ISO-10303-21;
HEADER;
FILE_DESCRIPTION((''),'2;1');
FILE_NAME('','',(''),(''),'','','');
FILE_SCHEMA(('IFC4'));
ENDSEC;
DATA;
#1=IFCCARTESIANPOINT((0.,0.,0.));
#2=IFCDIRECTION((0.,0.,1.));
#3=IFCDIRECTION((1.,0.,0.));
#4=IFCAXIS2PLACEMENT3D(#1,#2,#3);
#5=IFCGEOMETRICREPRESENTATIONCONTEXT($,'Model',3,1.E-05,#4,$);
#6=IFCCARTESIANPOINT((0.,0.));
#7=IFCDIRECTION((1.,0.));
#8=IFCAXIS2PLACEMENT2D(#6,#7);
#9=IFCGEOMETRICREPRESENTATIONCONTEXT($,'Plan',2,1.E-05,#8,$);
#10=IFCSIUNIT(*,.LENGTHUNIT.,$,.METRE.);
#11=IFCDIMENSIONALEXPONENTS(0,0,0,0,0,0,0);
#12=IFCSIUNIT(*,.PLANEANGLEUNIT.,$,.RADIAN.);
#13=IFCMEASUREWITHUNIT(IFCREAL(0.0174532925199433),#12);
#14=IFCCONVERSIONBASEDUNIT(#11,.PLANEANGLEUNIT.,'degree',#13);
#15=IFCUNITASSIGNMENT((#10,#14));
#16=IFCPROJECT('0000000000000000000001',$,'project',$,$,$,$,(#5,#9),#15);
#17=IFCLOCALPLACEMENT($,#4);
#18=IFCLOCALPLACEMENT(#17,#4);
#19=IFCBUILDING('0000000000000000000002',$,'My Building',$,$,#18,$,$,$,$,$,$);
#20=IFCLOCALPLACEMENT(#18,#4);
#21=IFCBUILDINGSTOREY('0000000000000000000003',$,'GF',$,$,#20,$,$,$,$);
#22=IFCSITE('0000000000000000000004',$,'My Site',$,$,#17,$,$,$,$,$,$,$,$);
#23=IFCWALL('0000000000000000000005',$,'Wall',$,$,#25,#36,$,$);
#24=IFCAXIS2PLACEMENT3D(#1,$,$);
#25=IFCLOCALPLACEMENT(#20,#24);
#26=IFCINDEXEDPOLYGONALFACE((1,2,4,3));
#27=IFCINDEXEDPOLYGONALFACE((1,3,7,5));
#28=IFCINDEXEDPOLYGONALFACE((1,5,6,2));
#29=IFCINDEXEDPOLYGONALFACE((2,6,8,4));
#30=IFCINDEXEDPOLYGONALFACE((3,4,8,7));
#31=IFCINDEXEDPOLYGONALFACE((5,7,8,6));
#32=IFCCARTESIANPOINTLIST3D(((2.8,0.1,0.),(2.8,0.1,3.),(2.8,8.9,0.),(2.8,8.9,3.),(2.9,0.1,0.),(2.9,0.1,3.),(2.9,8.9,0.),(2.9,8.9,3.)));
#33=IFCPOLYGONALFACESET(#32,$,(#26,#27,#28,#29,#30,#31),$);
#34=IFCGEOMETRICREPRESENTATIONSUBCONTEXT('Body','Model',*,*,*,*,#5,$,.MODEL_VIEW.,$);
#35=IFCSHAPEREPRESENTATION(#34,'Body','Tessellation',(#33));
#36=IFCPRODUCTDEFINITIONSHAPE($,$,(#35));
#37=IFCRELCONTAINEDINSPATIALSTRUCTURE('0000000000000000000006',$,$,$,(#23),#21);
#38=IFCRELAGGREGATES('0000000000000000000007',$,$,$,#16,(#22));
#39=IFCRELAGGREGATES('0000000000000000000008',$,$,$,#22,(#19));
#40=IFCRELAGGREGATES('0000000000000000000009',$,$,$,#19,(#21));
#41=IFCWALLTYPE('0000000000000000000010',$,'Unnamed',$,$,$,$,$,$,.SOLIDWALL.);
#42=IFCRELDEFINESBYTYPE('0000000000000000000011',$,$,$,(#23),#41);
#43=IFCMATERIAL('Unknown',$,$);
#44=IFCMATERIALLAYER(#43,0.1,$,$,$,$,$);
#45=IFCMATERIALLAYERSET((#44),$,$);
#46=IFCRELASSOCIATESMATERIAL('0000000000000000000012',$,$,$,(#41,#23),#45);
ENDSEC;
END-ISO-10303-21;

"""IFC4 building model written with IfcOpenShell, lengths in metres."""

from ifc_helpers import new_model, entity, si_unit, converted_unit, frame, origin_with_axes, origin_2d_with_axis, place, context, subcontext, project, spatial, line, indexed_curve, outline, extrude, material, layer, layer_set, layer_usage, type_object, element, save


model = new_model("IFC4")

# Units and contexts
model_context = context("Model", 3, precision=1e-05, world=origin_with_axes())
plan_context = context("Plan", 2, precision=1e-05, world=origin_2d_with_axis())
body_context_1 = subcontext(model_context, "Body", "Model", "MODEL_VIEW")
ifc_project = project(units=[si_unit("LENGTHUNIT", "METRE"), converted_unit("PLANEANGLEUNIT", "degree", entity("IfcReal", 0.0174532925199433), si_unit("PLANEANGLEUNIT", "RADIAN"), dimensions=[0, 0, 0, 0, 0, 0, 0])], contexts=[model_context, plan_context])

# Site, building, storey
site_placement = place(None, origin_with_axes())
site = spatial("IfcSite", under=ifc_project, at=site_placement, Name="My Site")
building_placement = place(site_placement, origin_with_axes())
building = spatial("IfcBuilding", under=site, at=building_placement, Name="My Building")
storey_placement = place(building_placement, origin_with_axes())
storey = spatial("IfcBuildingStorey", under=building, at=storey_placement, Name="GF")

# Shared definitions
ifc_material = material(Name="Unknown")

# Shared definitions
ifc_layer_1 = layer(ifc_material, 0.1)
ifc_layer_set_1 = layer_set([ifc_layer_1])
wall_type = type_object("IfcWallType", Name="Unnamed", PredefinedType="SOLIDWALL", material=ifc_layer_set_1)

# Wall
ifc_layer_usage_1 = layer_usage(ifc_layer_set_1, "AXIS2", "POSITIVE", 0.0)
wall_1_placement = place(storey_placement, frame((2.8, 9.0, 0.0), z_axis=(0.0, 0.0, 1.0), x_axis=(0.0, -1.0, 0.0)))
element("IfcWall", 1, at=wall_1_placement, inside=storey, type_object=wall_type, material=ifc_layer_usage_1, Name="Wall", context=body_context_1, shape_type="SweptSolid", body=[
    extrude(outline(indexed_curve([(0.1, 0.0), (0.1, 0.1), (8.9, 0.1), (8.9, 0.0)], segments=[line(1, 2, 3, 4, 1)])), origin_with_axes(), (0.0, 0.0, 1.0), 3.0),
])

save(model, "model.ifc")
